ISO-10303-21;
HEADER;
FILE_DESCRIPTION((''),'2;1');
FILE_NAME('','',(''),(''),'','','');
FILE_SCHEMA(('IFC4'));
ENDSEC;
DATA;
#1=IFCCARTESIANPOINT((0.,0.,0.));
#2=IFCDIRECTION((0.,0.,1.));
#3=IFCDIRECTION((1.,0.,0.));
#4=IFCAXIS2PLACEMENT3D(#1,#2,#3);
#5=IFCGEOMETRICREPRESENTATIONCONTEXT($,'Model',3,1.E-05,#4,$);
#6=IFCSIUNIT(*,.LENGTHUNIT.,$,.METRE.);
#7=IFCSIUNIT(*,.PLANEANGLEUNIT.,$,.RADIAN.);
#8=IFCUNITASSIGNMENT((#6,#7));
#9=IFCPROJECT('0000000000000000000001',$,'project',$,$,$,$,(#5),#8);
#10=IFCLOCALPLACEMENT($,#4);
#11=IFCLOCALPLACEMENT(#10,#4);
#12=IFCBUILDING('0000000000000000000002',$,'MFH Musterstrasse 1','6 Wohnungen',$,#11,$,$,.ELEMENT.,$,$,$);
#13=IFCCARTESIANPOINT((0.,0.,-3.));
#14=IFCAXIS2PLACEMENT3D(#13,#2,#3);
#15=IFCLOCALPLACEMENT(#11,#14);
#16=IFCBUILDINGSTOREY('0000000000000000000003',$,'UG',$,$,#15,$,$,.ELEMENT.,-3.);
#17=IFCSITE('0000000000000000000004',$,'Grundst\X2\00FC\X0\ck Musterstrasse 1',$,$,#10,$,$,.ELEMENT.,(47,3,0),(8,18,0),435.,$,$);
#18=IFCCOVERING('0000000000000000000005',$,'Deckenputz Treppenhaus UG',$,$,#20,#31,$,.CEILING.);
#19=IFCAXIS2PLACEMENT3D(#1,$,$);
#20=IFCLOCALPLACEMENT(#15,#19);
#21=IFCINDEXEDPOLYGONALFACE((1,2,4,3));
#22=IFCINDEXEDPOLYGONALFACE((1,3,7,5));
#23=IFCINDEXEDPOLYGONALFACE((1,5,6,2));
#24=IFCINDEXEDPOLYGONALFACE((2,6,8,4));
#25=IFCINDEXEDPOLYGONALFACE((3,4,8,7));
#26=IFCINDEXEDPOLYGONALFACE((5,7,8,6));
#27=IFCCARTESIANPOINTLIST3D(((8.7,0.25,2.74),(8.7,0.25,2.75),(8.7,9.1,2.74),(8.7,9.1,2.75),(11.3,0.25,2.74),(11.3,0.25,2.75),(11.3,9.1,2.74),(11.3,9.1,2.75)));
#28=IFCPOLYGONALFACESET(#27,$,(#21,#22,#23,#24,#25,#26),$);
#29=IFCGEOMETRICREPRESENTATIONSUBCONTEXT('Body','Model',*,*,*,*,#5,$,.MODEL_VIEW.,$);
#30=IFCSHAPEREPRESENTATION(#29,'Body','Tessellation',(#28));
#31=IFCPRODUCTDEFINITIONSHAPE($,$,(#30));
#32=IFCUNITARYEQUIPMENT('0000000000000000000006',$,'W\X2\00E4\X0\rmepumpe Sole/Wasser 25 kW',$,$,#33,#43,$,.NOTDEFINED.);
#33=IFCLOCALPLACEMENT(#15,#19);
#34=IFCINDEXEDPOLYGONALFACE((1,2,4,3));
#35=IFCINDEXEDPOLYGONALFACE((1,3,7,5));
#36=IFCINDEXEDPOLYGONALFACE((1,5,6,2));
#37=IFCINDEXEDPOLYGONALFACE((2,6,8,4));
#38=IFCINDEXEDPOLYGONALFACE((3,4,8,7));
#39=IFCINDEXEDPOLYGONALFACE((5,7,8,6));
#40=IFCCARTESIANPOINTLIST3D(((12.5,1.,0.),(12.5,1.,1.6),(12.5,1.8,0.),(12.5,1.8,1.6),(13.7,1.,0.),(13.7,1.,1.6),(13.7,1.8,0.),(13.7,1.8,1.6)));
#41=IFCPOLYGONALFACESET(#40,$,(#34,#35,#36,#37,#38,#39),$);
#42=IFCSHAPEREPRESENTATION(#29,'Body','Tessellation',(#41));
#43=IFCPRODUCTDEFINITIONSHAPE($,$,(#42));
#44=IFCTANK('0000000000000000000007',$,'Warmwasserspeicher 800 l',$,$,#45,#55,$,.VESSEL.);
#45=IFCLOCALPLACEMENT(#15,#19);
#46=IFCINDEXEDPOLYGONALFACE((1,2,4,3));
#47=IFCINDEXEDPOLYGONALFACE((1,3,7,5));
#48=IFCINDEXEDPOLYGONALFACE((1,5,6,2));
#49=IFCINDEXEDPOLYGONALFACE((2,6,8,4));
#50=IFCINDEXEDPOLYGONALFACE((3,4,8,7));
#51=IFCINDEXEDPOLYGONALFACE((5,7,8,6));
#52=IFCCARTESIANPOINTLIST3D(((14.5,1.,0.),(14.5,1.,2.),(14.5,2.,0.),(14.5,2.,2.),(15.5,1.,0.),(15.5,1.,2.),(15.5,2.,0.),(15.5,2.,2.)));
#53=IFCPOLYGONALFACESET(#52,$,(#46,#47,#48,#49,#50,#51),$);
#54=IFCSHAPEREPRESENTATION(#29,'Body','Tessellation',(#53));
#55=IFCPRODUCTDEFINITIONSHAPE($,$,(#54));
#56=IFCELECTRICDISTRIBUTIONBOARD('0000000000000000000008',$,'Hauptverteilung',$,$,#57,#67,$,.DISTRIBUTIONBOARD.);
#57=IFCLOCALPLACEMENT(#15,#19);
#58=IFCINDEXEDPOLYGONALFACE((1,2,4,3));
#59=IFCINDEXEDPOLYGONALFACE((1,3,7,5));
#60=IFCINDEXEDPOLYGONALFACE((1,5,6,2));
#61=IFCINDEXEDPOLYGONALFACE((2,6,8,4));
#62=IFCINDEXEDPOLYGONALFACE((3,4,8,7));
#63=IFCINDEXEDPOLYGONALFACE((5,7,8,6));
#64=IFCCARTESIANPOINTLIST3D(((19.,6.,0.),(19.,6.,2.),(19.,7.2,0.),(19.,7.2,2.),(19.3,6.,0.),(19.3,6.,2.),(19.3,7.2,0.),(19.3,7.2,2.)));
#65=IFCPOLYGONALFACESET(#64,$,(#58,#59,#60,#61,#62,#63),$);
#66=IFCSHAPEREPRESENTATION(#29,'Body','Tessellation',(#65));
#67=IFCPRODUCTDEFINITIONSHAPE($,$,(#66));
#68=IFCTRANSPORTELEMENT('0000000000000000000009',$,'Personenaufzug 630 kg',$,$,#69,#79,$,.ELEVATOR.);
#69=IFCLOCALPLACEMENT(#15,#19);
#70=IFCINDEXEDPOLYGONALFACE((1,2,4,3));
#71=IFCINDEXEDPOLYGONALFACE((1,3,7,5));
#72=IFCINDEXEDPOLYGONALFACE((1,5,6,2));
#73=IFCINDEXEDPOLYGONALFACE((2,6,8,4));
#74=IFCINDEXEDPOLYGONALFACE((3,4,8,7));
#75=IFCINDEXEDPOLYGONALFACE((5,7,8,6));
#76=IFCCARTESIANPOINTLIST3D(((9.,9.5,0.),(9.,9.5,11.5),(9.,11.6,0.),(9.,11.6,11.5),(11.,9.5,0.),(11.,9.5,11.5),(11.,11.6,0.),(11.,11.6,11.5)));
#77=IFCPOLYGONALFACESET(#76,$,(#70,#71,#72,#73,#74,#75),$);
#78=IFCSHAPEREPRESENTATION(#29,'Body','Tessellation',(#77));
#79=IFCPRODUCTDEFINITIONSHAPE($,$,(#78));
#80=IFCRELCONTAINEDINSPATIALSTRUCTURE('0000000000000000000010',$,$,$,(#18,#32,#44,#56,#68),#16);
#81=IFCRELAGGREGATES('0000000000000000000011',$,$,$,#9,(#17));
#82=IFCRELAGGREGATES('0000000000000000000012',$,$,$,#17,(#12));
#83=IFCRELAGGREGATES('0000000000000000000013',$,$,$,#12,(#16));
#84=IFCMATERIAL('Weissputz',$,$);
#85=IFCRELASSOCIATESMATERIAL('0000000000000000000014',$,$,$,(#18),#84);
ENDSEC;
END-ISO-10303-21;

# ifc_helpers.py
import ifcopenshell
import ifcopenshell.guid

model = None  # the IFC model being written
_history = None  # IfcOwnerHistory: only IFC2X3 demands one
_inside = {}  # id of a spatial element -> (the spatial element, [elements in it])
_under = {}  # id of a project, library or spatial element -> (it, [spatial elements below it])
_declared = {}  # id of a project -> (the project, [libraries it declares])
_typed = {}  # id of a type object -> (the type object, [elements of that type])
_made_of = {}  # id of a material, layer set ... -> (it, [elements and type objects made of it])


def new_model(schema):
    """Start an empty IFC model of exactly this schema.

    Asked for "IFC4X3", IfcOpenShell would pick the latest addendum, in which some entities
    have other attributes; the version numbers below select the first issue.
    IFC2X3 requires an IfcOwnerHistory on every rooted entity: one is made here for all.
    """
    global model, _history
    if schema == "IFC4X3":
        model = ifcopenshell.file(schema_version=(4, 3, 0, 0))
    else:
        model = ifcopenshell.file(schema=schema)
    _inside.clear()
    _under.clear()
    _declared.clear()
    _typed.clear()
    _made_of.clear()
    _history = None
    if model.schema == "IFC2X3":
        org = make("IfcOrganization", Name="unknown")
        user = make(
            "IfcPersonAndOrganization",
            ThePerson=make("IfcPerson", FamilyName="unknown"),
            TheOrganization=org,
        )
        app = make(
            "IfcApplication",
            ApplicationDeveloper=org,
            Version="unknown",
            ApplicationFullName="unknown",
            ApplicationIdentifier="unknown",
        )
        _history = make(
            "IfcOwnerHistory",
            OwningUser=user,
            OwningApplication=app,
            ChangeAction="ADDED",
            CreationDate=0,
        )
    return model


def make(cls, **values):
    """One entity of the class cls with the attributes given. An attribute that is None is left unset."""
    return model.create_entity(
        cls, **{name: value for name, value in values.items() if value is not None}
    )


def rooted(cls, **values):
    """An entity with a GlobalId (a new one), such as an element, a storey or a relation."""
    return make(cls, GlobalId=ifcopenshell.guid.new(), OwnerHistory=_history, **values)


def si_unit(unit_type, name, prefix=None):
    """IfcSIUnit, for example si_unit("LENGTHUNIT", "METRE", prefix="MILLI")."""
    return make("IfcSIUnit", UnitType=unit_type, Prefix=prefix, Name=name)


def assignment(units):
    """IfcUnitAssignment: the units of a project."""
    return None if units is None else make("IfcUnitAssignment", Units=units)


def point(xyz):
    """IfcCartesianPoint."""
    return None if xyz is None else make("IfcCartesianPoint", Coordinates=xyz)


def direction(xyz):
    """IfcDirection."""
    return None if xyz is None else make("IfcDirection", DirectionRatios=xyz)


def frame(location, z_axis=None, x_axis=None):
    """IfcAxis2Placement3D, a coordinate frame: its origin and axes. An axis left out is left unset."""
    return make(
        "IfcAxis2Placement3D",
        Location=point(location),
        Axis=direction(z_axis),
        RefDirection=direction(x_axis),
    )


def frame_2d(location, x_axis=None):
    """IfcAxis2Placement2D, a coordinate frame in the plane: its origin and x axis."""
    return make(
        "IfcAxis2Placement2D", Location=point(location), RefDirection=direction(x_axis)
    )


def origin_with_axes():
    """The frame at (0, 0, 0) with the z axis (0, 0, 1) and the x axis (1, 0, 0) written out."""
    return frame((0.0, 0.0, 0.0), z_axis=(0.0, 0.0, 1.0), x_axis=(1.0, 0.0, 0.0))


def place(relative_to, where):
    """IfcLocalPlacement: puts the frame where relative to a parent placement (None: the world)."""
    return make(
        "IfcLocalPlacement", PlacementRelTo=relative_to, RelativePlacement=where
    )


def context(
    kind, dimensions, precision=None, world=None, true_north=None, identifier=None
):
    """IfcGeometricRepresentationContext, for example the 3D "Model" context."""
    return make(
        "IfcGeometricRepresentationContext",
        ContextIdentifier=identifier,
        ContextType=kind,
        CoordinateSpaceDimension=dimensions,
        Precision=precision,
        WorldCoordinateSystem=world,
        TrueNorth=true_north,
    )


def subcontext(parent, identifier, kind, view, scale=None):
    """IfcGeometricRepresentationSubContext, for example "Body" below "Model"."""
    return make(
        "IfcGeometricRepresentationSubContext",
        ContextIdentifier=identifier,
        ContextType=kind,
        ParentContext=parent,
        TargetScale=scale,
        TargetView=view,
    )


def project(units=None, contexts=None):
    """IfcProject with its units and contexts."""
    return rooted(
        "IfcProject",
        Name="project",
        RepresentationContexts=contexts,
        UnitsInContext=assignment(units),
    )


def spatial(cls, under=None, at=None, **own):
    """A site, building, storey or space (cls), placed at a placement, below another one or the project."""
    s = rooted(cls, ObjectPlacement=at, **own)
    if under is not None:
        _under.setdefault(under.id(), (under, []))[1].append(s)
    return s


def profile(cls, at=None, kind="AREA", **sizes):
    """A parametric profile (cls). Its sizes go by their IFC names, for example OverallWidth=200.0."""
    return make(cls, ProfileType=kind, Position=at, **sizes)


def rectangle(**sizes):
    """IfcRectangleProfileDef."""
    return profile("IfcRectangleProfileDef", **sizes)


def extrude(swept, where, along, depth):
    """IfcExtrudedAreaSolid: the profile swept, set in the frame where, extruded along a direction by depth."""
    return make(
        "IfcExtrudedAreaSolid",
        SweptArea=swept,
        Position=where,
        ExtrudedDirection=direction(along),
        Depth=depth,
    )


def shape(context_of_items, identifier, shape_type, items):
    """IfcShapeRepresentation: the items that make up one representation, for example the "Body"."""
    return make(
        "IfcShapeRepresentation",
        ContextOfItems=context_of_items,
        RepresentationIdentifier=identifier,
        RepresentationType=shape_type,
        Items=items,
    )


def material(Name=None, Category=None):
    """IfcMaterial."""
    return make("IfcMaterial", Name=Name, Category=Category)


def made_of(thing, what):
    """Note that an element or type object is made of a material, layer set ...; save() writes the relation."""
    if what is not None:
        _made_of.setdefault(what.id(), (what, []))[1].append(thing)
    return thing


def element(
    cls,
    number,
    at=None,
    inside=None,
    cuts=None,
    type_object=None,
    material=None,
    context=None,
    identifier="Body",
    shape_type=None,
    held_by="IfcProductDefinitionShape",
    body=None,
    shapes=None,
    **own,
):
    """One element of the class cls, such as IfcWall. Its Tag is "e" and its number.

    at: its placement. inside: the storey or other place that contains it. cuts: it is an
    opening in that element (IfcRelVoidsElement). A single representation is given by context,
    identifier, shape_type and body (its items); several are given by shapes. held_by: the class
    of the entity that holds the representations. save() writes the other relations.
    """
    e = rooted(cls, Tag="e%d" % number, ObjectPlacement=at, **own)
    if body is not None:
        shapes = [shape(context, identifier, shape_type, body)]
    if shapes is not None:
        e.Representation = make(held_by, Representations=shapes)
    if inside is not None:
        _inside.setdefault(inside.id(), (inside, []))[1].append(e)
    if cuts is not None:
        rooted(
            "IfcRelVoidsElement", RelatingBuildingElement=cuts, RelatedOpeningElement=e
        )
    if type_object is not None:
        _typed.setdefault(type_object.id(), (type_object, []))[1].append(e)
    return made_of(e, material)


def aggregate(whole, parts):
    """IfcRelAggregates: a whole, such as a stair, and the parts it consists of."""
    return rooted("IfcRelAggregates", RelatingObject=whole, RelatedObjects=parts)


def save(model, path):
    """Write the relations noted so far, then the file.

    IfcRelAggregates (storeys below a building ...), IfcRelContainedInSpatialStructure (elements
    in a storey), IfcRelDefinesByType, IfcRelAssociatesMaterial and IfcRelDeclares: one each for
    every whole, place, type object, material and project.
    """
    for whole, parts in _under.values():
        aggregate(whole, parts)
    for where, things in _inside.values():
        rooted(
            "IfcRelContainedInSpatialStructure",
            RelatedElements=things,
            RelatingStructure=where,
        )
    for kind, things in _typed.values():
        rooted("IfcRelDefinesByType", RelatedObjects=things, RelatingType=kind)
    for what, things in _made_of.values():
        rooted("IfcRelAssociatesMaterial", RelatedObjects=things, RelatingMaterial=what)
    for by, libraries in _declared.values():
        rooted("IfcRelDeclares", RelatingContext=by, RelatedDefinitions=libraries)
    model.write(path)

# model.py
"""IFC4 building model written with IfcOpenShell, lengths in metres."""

from ifc_helpers import new_model, si_unit, frame, frame_2d, origin_with_axes, place, context, subcontext, project, spatial, rectangle, extrude, material, element, save


model = new_model("IFC4")

# Units and contexts
model_context = context("Model", 3, precision=1e-05, world=origin_with_axes())
body_context = subcontext(model_context, "Body", "Model", "MODEL_VIEW")
ifc_project = project(units=[si_unit("LENGTHUNIT", "METRE"), si_unit("PLANEANGLEUNIT", "RADIAN")], contexts=[model_context])

# Site, building, storey
site_placement = place(None, origin_with_axes())
site = spatial("IfcSite", under=ifc_project, at=site_placement, Name="Grundstück Musterstrasse 1", CompositionType="ELEMENT", RefLatitude=(47, 3, 0), RefLongitude=(8, 18, 0), RefElevation=435.0)
building_placement = place(site_placement, origin_with_axes())
building = spatial("IfcBuilding", under=site, at=building_placement, Name="MFH Musterstrasse 1", Description="6 Wohnungen", CompositionType="ELEMENT")
storey_placement = place(building_placement, frame((0.0, 0.0, -3.0), z_axis=(0.0, 0.0, 1.0), x_axis=(1.0, 0.0, 0.0)))
storey = spatial("IfcBuildingStorey", under=building, at=storey_placement, Name="UG", CompositionType="ELEMENT", Elevation=-3.0)

# Covering
ifc_material_1 = material(Name="Weissputz")
covering_1_placement = place(storey_placement, origin_with_axes())
element("IfcCovering", 1, at=covering_1_placement, inside=storey, material=ifc_material_1, Name="Deckenputz Treppenhaus UG", PredefinedType="CEILING", context=body_context, shape_type="SweptSolid", body=[
    extrude(rectangle(XDim=2.6, YDim=8.85, at=frame_2d((1.3, 4.425), x_axis=(1.0, 0.0))), frame((8.7, 0.25, 2.74), z_axis=(0.0, 0.0, 1.0), x_axis=(1.0, 0.0, 0.0)), (0.0, 0.0, 1.0), 0.01),
])

# Unitary equipment
unitary_equipment_placement = place(storey_placement, origin_with_axes())
element("IfcUnitaryEquipment", 2, at=unitary_equipment_placement, inside=storey, Name="Wärmepumpe Sole/Wasser 25 kW", PredefinedType="NOTDEFINED", context=body_context, shape_type="SweptSolid", body=[
    extrude(rectangle(XDim=1.2, YDim=0.8, at=frame_2d((0.6, 0.4), x_axis=(1.0, 0.0))), frame((12.5, 1.0, 0.0), z_axis=(0.0, 0.0, 1.0), x_axis=(1.0, 0.0, 0.0)), (0.0, 0.0, 1.0), 1.6),
])

# Tank
tank_placement = place(storey_placement, origin_with_axes())
element("IfcTank", 3, at=tank_placement, inside=storey, Name="Warmwasserspeicher 800 l", PredefinedType="VESSEL", context=body_context, shape_type="SweptSolid", body=[
    extrude(rectangle(XDim=1.0, YDim=1.0, at=frame_2d((0.5, 0.5), x_axis=(1.0, 0.0))), frame((14.5, 1.0, 0.0), z_axis=(0.0, 0.0, 1.0), x_axis=(1.0, 0.0, 0.0)), (0.0, 0.0, 1.0), 2.0),
])

# Electric distribution board
electric_distribution_board_placement = place(storey_placement, origin_with_axes())
element("IfcElectricDistributionBoard", 4, at=electric_distribution_board_placement, inside=storey, Name="Hauptverteilung", PredefinedType="DISTRIBUTIONBOARD", context=body_context, shape_type="SweptSolid", body=[
    extrude(rectangle(XDim=0.3, YDim=1.2, at=frame_2d((0.15, 0.6), x_axis=(1.0, 0.0))), frame((19.0, 6.0, 0.0), z_axis=(0.0, 0.0, 1.0), x_axis=(1.0, 0.0, 0.0)), (0.0, 0.0, 1.0), 2.0),
])

# Transport element
transport_element_placement = place(storey_placement, origin_with_axes())
element("IfcTransportElement", 5, at=transport_element_placement, inside=storey, Name="Personenaufzug 630 kg", PredefinedType="ELEVATOR", context=body_context, shape_type="SweptSolid", body=[
    extrude(rectangle(XDim=2.0, YDim=2.1, at=frame_2d((1.0, 1.05), x_axis=(1.0, 0.0))), frame((9.0, 9.5, 0.0), z_axis=(0.0, 0.0, 1.0), x_axis=(1.0, 0.0, 0.0)), (0.0, 0.0, 1.0), 11.5),
])

save(model, "model.ifc")
